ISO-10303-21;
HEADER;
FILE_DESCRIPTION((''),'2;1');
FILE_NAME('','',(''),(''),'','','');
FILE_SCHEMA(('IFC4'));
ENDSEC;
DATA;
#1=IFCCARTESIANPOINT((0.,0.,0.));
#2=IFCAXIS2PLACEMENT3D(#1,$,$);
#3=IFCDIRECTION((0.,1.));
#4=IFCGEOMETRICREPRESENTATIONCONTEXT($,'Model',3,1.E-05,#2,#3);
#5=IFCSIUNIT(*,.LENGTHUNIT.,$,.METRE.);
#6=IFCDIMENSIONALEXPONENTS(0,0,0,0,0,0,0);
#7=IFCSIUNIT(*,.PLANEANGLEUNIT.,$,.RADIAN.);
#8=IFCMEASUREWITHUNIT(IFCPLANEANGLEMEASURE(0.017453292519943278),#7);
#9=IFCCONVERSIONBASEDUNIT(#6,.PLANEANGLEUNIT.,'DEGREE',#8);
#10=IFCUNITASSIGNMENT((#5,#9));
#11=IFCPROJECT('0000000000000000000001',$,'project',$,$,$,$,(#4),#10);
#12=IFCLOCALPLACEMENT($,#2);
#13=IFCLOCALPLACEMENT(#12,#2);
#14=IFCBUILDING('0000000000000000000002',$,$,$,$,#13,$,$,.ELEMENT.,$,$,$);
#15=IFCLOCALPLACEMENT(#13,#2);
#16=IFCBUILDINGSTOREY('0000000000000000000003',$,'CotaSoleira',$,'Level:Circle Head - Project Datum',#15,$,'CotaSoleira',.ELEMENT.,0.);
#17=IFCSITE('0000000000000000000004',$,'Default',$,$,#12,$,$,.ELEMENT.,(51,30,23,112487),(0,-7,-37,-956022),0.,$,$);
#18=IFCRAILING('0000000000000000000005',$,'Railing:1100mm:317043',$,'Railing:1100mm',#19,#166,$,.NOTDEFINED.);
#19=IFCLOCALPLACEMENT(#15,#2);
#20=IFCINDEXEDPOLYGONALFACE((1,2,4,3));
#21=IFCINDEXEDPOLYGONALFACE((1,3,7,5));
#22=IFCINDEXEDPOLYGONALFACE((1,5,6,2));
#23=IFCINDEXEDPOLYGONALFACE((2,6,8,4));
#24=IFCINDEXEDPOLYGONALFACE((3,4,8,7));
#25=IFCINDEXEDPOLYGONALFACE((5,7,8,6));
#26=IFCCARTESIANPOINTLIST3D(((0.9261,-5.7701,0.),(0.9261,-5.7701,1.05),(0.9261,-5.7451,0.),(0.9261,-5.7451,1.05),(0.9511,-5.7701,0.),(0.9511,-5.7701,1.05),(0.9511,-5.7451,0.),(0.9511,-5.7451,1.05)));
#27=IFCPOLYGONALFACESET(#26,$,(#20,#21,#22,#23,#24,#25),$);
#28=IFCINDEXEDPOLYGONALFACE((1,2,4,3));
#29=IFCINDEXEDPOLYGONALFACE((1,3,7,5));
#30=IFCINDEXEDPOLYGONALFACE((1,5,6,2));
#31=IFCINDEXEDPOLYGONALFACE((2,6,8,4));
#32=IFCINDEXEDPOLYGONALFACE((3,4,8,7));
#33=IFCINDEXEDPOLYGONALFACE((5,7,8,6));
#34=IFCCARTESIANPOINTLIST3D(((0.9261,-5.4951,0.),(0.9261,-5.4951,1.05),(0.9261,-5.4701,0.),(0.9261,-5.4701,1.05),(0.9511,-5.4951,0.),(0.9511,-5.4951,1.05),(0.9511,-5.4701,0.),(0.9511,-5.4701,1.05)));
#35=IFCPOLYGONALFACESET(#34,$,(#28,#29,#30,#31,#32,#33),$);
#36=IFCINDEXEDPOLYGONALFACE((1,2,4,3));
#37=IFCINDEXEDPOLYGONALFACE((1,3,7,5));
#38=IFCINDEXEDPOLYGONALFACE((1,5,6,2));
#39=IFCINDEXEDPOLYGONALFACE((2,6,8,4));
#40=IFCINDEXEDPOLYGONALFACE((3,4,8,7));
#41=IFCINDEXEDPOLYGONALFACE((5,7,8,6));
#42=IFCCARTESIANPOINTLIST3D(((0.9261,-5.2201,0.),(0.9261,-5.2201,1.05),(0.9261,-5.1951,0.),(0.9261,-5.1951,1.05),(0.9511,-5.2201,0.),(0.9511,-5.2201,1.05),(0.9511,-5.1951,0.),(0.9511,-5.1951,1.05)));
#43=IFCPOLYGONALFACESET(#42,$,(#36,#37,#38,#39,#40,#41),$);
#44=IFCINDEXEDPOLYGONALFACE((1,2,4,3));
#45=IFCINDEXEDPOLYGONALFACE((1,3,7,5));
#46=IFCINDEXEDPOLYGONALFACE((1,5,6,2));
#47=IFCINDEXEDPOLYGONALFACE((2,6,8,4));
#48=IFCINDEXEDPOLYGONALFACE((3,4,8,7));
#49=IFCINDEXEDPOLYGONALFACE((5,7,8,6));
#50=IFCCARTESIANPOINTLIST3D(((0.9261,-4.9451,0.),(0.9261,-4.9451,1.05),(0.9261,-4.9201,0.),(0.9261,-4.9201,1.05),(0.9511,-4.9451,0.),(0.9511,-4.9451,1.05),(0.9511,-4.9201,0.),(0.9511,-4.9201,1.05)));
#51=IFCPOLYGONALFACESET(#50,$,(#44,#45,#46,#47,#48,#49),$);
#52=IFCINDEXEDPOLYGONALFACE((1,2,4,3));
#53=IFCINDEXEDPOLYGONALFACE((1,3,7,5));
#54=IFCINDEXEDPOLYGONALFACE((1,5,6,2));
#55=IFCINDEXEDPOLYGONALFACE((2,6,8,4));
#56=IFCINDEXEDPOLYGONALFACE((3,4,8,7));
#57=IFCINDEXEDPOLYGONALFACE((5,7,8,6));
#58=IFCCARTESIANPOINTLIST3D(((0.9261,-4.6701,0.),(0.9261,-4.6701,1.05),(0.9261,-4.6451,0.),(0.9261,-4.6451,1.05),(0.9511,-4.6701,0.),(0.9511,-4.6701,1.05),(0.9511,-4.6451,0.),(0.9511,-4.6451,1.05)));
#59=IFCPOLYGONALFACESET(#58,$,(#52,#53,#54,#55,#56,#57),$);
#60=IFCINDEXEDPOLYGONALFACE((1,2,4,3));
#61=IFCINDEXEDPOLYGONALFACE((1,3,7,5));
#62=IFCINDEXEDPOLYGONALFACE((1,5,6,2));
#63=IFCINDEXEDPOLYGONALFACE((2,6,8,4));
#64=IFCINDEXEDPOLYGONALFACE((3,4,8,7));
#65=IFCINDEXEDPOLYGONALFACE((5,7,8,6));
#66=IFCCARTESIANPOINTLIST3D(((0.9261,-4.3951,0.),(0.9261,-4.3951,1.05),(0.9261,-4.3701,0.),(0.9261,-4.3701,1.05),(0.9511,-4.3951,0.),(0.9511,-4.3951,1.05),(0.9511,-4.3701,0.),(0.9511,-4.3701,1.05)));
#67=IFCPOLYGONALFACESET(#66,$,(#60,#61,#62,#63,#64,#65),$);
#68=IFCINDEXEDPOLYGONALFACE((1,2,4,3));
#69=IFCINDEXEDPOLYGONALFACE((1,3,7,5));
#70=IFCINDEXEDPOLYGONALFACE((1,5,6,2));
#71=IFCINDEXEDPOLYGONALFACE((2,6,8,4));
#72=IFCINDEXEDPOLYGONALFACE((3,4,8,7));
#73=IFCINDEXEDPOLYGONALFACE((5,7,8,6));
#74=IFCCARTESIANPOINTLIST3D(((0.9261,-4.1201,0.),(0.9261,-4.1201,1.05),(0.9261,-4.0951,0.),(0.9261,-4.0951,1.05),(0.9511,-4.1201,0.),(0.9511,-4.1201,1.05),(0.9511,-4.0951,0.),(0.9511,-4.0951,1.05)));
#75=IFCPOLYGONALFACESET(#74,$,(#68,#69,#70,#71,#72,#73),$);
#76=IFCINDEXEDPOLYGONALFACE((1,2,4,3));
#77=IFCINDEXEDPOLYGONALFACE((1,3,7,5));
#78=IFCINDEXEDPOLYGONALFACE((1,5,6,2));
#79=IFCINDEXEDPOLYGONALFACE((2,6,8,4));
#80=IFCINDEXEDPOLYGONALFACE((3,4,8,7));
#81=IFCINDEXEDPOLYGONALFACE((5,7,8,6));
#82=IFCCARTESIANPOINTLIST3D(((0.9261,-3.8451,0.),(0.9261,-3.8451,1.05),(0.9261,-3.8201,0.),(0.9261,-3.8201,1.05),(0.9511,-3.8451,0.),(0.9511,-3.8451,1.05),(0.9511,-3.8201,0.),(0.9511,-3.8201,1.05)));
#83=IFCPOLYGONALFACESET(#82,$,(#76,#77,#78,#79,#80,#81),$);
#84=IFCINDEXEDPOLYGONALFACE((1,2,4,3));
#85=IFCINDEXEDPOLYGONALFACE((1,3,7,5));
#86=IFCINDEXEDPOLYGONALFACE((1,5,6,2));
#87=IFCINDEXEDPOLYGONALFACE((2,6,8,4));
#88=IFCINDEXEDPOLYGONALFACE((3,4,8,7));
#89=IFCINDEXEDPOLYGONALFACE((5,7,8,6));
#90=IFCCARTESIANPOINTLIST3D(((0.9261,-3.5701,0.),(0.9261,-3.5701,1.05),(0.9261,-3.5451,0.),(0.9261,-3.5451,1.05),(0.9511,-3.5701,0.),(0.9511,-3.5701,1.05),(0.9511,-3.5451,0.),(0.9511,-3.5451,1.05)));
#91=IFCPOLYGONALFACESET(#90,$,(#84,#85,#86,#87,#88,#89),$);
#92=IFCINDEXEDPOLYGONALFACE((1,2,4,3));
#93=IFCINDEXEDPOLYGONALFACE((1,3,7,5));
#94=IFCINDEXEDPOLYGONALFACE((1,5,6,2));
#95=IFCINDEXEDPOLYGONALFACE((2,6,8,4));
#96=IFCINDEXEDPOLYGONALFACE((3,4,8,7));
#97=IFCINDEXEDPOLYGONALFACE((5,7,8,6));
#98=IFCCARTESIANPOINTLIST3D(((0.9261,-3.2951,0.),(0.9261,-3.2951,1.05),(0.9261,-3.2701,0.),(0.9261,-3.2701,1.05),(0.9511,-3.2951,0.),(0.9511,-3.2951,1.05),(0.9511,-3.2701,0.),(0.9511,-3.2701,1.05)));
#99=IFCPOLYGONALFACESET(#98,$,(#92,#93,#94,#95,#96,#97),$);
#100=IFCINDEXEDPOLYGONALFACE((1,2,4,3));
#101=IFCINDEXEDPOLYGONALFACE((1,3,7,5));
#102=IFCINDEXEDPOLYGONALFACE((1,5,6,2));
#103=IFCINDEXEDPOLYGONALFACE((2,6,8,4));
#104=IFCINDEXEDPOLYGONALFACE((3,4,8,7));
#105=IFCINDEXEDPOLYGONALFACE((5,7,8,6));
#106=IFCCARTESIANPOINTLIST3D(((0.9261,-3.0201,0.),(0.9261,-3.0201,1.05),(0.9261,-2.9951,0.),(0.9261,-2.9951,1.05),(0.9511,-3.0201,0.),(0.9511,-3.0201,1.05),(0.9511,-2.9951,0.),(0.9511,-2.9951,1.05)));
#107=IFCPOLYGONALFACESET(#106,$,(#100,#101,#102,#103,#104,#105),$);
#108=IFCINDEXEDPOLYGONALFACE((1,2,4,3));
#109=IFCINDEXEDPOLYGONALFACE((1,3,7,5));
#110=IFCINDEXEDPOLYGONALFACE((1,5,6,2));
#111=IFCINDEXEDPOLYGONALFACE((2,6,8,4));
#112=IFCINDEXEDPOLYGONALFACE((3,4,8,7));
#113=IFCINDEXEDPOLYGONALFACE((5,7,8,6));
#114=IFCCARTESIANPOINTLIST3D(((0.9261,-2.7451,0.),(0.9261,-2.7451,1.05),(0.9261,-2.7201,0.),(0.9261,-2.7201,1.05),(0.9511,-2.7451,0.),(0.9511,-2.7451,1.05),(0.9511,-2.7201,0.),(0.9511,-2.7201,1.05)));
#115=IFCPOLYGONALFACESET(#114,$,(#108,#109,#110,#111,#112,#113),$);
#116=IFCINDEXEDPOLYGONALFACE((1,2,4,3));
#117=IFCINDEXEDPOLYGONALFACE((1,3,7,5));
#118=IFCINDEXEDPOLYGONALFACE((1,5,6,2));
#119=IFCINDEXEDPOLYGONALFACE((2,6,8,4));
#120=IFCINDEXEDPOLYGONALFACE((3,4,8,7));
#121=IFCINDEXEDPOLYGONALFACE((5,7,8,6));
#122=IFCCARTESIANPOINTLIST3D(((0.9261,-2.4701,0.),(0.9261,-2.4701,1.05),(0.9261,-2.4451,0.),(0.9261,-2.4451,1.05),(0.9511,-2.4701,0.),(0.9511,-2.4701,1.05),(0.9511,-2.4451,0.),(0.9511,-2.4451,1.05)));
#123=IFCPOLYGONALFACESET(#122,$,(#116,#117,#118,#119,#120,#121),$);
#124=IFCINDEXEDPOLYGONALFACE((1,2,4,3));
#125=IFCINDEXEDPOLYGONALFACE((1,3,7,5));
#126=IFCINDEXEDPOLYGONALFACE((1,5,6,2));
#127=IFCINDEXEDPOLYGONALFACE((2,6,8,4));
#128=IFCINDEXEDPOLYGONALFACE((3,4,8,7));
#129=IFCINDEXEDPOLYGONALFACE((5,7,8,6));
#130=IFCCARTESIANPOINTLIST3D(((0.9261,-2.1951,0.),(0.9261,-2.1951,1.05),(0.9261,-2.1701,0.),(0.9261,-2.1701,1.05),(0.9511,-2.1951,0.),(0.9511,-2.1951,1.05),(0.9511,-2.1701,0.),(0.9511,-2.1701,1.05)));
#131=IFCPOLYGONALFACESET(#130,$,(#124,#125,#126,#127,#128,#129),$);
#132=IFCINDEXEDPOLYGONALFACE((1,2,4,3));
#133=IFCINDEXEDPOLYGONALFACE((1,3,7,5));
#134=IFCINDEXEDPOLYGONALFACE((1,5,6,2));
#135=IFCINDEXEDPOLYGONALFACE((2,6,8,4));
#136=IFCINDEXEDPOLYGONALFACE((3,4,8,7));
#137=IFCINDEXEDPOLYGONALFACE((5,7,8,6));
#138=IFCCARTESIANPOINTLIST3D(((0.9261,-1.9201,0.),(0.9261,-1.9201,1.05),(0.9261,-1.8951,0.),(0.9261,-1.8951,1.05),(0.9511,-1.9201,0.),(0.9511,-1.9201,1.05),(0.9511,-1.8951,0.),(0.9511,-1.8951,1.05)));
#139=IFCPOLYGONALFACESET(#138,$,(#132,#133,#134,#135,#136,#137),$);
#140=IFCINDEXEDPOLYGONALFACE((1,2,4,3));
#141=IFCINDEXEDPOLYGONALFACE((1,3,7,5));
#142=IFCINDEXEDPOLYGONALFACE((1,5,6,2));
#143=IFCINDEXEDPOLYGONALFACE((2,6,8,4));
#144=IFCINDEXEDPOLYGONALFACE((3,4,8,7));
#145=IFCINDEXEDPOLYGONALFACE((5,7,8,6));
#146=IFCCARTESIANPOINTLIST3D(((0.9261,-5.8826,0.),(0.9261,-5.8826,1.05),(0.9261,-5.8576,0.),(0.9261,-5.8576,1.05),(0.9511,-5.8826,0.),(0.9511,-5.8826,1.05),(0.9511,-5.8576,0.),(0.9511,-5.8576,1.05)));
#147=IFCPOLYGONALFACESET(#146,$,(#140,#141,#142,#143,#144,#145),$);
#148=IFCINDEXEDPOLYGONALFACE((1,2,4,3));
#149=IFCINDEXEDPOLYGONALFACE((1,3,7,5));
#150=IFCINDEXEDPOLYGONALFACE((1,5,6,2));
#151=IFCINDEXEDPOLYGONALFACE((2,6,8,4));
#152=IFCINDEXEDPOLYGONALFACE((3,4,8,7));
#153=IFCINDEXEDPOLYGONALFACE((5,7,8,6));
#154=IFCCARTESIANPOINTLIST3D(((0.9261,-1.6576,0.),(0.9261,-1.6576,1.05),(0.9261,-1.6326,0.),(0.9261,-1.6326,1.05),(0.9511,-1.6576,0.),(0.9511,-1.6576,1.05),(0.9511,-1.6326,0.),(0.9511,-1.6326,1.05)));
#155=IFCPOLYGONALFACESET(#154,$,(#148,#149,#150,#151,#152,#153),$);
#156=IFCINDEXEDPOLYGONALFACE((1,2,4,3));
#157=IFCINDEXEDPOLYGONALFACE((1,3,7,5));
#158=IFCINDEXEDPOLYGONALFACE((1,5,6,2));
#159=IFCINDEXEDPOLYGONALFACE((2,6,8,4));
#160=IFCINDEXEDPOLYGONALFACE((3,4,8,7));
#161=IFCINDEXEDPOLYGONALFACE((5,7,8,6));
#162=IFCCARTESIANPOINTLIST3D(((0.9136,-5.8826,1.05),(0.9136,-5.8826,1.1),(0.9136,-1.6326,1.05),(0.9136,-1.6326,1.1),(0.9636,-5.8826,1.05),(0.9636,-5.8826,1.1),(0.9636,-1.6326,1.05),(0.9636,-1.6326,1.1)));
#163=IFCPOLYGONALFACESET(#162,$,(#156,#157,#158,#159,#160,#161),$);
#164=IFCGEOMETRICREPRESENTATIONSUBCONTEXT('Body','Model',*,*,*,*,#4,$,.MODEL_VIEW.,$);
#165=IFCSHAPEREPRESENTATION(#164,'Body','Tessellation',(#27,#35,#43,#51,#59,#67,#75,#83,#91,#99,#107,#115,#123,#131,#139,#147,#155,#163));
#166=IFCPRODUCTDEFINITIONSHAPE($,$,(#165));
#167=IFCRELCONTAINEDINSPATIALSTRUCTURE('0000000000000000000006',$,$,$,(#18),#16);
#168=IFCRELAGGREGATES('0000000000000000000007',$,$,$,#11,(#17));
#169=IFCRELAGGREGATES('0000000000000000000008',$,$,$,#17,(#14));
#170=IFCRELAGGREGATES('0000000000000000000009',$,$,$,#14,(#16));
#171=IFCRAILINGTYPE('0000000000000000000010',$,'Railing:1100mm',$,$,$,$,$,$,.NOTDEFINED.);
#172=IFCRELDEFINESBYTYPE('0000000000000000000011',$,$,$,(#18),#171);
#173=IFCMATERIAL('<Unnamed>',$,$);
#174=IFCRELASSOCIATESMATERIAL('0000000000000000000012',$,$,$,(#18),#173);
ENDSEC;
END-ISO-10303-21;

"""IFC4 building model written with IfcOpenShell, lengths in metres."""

from ifc_helpers import new_model, entity, si_unit, converted_unit, direction, frame, origin, place, context, subcontext, project, spatial, indexed_curve, outline, extrude, material, type_object, element, save


model = new_model("IFC4")

# Units and contexts
model_context = context("Model", 3, precision=1e-05, world=origin(), true_north=direction((0.0, 1.0)))
body_context = subcontext(model_context, "Body", "Model", "MODEL_VIEW")
ifc_project = project(units=[si_unit("LENGTHUNIT", "METRE"), converted_unit("PLANEANGLEUNIT", "DEGREE", entity("IfcPlaneAngleMeasure", 0.017453292519943278), si_unit("PLANEANGLEUNIT", "RADIAN"), dimensions=[0, 0, 0, 0, 0, 0, 0])], contexts=[model_context])

# Site, building, storey
site_placement = place(None, origin())
site = spatial("IfcSite", under=ifc_project, at=site_placement, Name="Default", CompositionType="ELEMENT", RefLatitude=(51, 30, 23, 112487), RefLongitude=(0, -7, -37, -956022), RefElevation=0.0)
building_placement = place(site_placement, origin())
building = spatial("IfcBuilding", under=site, at=building_placement, CompositionType="ELEMENT")
storey_placement = place(building_placement, origin())
storey = spatial("IfcBuildingStorey", under=building, at=storey_placement, Name="CotaSoleira", ObjectType="Level:Circle Head - Project Datum", LongName="CotaSoleira", CompositionType="ELEMENT", Elevation=0.0)

# Shared definitions
ifc_material_1 = material(Name="<Unnamed>")

# Railing
railing_type = type_object("IfcRailingType", Name="Railing:1100mm", PredefinedType="NOTDEFINED")
railing_1_placement = place(storey_placement, origin())
element("IfcRailing", 1, at=railing_1_placement, inside=storey, type_object=railing_type, material=ifc_material_1, Name="Railing:1100mm:317043", ObjectType="Railing:1100mm", PredefinedType="NOTDEFINED", context=body_context, shape_type="SweptSolid", body=[
    extrude(outline(indexed_curve([(-0.0125, -0.0125), (0.0125, -0.0125), (0.0125, 0.0125), (-0.0125, 0.0125), (-0.0125, -0.0125)], self_intersect=False)), frame((0.9386, -5.7576, 0.0), z_axis=(0.0, 0.0, 1.0), x_axis=(0.0, -1.0, 0.0)), (0.0, 0.0, 1.0), 1.05),
    extrude(outline(indexed_curve([(-0.0125, -0.0125), (0.0125, -0.0125), (0.0125, 0.0125), (-0.0125, 0.0125), (-0.0125, -0.0125)], self_intersect=False)), frame((0.9386, -5.4826, 0.0), z_axis=(0.0, 0.0, 1.0), x_axis=(0.0, -1.0, 0.0)), (0.0, 0.0, 1.0), 1.05),
    extrude(outline(indexed_curve([(-0.0125, -0.0125), (0.0125, -0.0125), (0.0125, 0.0125), (-0.0125, 0.0125), (-0.0125, -0.0125)], self_intersect=False)), frame((0.9386, -5.2076, 0.0), z_axis=(0.0, 0.0, 1.0), x_axis=(0.0, -1.0, 0.0)), (0.0, 0.0, 1.0), 1.05),
    extrude(outline(indexed_curve([(-0.0125, -0.0125), (0.0125, -0.0125), (0.0125, 0.0125), (-0.0125, 0.0125), (-0.0125, -0.0125)], self_intersect=False)), frame((0.9386, -4.9326, 0.0), z_axis=(0.0, 0.0, 1.0), x_axis=(0.0, -1.0, 0.0)), (0.0, 0.0, 1.0), 1.05),
    extrude(outline(indexed_curve([(-0.0125, -0.0125), (0.0125, -0.0125), (0.0125, 0.0125), (-0.0125, 0.0125), (-0.0125, -0.0125)], self_intersect=False)), frame((0.9386, -4.6576, 0.0), z_axis=(0.0, 0.0, 1.0), x_axis=(0.0, -1.0, 0.0)), (0.0, 0.0, 1.0), 1.05),
    extrude(outline(indexed_curve([(-0.0125, -0.0125), (0.0125, -0.0125), (0.0125, 0.0125), (-0.0125, 0.0125), (-0.0125, -0.0125)], self_intersect=False)), frame((0.9386, -4.3826, 0.0), z_axis=(0.0, 0.0, 1.0), x_axis=(0.0, -1.0, 0.0)), (0.0, 0.0, 1.0), 1.05),
    extrude(outline(indexed_curve([(-0.0125, -0.0125), (0.0125, -0.0125), (0.0125, 0.0125), (-0.0125, 0.0125), (-0.0125, -0.0125)], self_intersect=False)), frame((0.9386, -4.1076, 0.0), z_axis=(0.0, 0.0, 1.0), x_axis=(0.0, -1.0, 0.0)), (0.0, 0.0, 1.0), 1.05),
    extrude(outline(indexed_curve([(-0.0125, -0.0125), (0.0125, -0.0125), (0.0125, 0.0125), (-0.0125, 0.0125), (-0.0125, -0.0125)], self_intersect=False)), frame((0.9386, -3.8326, 0.0), z_axis=(0.0, 0.0, 1.0), x_axis=(0.0, -1.0, 0.0)), (0.0, 0.0, 1.0), 1.05),
    extrude(outline(indexed_curve([(-0.0125, -0.0125), (0.0125, -0.0125), (0.0125, 0.0125), (-0.0125, 0.0125), (-0.0125, -0.0125)], self_intersect=False)), frame((0.9386, -3.5576, 0.0), z_axis=(0.0, 0.0, 1.0), x_axis=(0.0, -1.0, 0.0)), (0.0, 0.0, 1.0), 1.05),
    extrude(outline(indexed_curve([(-0.0125, -0.0125), (0.0125, -0.0125), (0.0125, 0.0125), (-0.0125, 0.0125), (-0.0125, -0.0125)], self_intersect=False)), frame((0.9386, -3.2826, 0.0), z_axis=(0.0, 0.0, 1.0), x_axis=(0.0, -1.0, 0.0)), (0.0, 0.0, 1.0), 1.05),
    extrude(outline(indexed_curve([(-0.0125, -0.0125), (0.0125, -0.0125), (0.0125, 0.0125), (-0.0125, 0.0125), (-0.0125, -0.0125)], self_intersect=False)), frame((0.9386, -3.0076, 0.0), z_axis=(0.0, 0.0, 1.0), x_axis=(0.0, -1.0, 0.0)), (0.0, 0.0, 1.0), 1.05),
    extrude(outline(indexed_curve([(-0.0125, -0.0125), (0.0125, -0.0125), (0.0125, 0.0125), (-0.0125, 0.0125), (-0.0125, -0.0125)], self_intersect=False)), frame((0.9386, -2.7326, 0.0), z_axis=(0.0, 0.0, 1.0), x_axis=(0.0, -1.0, 0.0)), (0.0, 0.0, 1.0), 1.05),
    extrude(outline(indexed_curve([(-0.0125, -0.0125), (0.0125, -0.0125), (0.0125, 0.0125), (-0.0125, 0.0125), (-0.0125, -0.0125)], self_intersect=False)), frame((0.9386, -2.4576, 0.0), z_axis=(0.0, 0.0, 1.0), x_axis=(0.0, -1.0, 0.0)), (0.0, 0.0, 1.0), 1.05),
    extrude(outline(indexed_curve([(-0.0125, -0.0125), (0.0125, -0.0125), (0.0125, 0.0125), (-0.0125, 0.0125), (-0.0125, -0.0125)], self_intersect=False)), frame((0.9386, -2.1826, 0.0), z_axis=(0.0, 0.0, 1.0), x_axis=(0.0, -1.0, 0.0)), (0.0, 0.0, 1.0), 1.05),
    extrude(outline(indexed_curve([(-0.0125, -0.0125), (0.0125, -0.0125), (0.0125, 0.0125), (-0.0125, 0.0125), (-0.0125, -0.0125)], self_intersect=False)), frame((0.9386, -1.9076, 0.0), z_axis=(0.0, 0.0, 1.0), x_axis=(0.0, -1.0, 0.0)), (0.0, 0.0, 1.0), 1.05),
    extrude(outline(indexed_curve([(-0.0125, -0.0125), (0.0125, -0.0125), (0.0125, 0.0125), (-0.0125, 0.0125), (-0.0125, -0.0125)], self_intersect=False)), frame((0.9386, -5.8701, 0.0), z_axis=(0.0, 0.0, 1.0), x_axis=(0.0, -1.0, 0.0)), (0.0, 0.0, 1.0), 1.05),
    extrude(outline(indexed_curve([(-0.0125, -0.0125), (0.0125, -0.0125), (0.0125, 0.0125), (-0.0125, 0.0125), (-0.0125, -0.0125)], self_intersect=False)), frame((0.9386, -1.6451, 0.0), z_axis=(0.0, 0.0, 1.0), x_axis=(0.0, -1.0, 0.0)), (0.0, 0.0, 1.0), 1.05),
    extrude(outline(indexed_curve([(-2.125, -0.025), (2.125, -0.025), (2.125, 0.025), (-2.125, 0.025), (-2.125, -0.025)], self_intersect=False)), frame((0.9386, -3.7576, 1.05), z_axis=(0.0, 0.0, 1.0), x_axis=(0.0, -1.0, 0.0)), (0.0, 0.0, 1.0), 0.05),
])

save(model, "model.ifc")
